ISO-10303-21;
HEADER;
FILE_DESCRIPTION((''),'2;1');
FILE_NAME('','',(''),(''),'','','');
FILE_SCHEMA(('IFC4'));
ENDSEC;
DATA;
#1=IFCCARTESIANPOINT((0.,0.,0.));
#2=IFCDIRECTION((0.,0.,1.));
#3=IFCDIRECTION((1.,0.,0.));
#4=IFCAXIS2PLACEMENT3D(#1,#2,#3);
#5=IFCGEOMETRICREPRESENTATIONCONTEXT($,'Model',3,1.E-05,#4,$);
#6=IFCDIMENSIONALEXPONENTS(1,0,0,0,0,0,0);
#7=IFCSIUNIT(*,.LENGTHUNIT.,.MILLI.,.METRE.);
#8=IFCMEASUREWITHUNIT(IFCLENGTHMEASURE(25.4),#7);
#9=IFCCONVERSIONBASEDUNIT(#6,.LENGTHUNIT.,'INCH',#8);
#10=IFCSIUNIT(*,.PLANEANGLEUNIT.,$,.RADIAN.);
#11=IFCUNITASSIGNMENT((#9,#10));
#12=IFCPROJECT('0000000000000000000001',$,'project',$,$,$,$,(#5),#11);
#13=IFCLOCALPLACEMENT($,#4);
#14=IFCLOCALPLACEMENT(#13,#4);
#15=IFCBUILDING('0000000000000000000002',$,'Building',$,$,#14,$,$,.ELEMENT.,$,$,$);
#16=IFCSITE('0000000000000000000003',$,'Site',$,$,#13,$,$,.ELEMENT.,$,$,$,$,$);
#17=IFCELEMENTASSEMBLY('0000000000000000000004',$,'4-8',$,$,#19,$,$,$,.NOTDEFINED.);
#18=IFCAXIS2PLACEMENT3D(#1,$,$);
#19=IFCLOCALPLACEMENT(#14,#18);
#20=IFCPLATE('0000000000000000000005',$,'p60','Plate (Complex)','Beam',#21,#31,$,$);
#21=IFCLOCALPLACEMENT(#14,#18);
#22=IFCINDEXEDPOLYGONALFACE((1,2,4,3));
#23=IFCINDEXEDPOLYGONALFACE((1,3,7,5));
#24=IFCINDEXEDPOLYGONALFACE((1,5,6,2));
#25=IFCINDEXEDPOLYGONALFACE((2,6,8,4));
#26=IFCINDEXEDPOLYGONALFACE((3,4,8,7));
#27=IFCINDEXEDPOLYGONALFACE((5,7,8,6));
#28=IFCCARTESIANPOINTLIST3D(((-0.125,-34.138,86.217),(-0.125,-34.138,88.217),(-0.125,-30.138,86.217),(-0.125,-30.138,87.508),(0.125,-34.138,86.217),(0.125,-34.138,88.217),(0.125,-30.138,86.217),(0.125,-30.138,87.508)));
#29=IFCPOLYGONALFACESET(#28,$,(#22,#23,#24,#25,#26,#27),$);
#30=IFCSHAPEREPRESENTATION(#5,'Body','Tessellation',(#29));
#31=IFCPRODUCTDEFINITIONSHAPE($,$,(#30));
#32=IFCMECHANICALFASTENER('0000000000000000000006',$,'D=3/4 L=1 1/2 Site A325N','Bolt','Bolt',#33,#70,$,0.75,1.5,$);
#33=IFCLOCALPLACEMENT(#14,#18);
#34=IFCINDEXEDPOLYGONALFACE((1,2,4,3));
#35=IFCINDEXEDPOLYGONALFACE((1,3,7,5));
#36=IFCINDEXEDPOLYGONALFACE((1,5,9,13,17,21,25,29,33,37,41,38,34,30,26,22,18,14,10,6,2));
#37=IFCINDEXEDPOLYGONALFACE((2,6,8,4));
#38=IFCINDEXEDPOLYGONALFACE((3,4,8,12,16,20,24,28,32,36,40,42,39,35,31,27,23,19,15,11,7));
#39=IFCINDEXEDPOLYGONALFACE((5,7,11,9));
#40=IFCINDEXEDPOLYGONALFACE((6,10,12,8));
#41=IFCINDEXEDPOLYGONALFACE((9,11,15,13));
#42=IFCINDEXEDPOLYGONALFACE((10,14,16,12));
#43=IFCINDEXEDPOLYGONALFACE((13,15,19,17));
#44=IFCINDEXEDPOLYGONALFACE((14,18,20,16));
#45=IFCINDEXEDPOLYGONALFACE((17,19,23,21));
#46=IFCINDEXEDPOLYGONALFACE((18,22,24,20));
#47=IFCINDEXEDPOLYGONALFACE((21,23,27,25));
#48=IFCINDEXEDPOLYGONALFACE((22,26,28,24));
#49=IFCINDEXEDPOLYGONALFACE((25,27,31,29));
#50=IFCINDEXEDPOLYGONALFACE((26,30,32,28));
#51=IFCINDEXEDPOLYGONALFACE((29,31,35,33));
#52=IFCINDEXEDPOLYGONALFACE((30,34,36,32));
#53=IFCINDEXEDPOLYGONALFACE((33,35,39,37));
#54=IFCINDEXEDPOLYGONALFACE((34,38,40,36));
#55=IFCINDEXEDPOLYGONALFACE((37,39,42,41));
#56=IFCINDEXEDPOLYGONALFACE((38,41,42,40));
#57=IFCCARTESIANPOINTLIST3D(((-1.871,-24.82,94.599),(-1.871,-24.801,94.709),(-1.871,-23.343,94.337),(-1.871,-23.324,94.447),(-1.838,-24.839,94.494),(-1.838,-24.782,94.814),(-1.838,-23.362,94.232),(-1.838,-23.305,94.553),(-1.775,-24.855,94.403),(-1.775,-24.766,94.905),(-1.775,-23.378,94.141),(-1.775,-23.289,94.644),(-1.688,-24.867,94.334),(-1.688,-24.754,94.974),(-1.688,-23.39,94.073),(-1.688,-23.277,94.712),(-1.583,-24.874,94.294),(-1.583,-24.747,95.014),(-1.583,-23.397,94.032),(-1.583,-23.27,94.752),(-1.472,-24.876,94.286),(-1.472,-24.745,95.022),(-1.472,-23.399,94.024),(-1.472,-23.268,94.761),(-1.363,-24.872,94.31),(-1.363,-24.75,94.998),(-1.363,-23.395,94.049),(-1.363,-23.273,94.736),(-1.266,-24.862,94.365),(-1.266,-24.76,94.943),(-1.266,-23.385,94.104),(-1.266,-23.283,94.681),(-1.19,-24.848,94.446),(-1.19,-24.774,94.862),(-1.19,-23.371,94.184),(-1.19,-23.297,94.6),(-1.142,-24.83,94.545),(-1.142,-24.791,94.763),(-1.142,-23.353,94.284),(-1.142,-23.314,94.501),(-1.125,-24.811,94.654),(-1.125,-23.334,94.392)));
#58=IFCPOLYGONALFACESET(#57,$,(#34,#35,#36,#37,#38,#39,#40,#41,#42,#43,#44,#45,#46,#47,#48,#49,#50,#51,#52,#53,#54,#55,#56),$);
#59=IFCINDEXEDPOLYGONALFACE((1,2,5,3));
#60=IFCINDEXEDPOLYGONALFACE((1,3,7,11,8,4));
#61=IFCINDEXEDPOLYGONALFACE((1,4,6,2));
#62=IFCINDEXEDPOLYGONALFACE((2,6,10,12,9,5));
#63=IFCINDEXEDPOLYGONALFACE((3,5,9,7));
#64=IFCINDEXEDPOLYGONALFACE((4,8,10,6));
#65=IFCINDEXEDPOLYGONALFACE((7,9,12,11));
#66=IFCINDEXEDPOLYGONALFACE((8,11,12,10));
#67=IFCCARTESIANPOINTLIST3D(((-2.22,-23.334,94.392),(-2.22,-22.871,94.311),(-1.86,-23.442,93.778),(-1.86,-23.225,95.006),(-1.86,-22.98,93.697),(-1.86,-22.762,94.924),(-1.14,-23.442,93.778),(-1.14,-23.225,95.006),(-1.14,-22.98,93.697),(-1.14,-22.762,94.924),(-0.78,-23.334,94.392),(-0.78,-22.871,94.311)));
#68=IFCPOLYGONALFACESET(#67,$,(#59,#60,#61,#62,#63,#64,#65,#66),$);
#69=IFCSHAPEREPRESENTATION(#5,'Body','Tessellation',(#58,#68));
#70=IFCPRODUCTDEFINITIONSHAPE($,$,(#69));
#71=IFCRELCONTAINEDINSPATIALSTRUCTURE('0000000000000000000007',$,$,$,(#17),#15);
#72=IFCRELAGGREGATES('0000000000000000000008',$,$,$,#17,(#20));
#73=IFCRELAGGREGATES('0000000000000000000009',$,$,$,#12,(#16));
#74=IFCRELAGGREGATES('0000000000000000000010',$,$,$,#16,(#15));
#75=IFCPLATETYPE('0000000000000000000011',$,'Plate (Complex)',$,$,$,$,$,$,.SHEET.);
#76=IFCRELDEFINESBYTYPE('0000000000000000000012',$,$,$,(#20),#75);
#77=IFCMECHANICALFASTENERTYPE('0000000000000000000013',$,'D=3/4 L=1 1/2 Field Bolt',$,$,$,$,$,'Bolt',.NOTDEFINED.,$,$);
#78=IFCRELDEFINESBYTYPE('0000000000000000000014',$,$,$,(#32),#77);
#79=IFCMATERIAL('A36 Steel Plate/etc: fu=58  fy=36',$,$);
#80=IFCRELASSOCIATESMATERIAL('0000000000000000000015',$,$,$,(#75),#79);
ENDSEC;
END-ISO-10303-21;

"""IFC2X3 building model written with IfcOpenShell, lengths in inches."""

from ifc_helpers import new_model, entity, si_unit, converted_unit, frame, origin_with_axes, origin_2d_with_axis, place, context, project, spatial, polyline, circle, outline, extrude, source, transform, mapped, material, type_object, type_shapes, element, aggregate, save


model = new_model("IFC2X3")

# Units and contexts
model_context = context("Model", 3, precision=1e-05, world=origin_with_axes())
ifc_project = project(units=[converted_unit("LENGTHUNIT", "INCH", entity("IfcLengthMeasure", 25.4), si_unit("LENGTHUNIT", "METRE", prefix="MILLI"), dimensions=[1, 0, 0, 0, 0, 0, 0]), si_unit("PLANEANGLEUNIT", "RADIAN")], contexts=[model_context])

# Site, building
site_placement = place(None, origin_with_axes())
site = spatial("IfcSite", under=ifc_project, at=site_placement, Name="Site", CompositionType="ELEMENT")
building_placement = place(site_placement, origin_with_axes())
building = spatial("IfcBuilding", under=site, at=building_placement, Name="Building", CompositionType="ELEMENT")

# Element assembly
assembly_1_placement = place(building_placement, frame((0.0, -48.0, 94.0), z_axis=(0.0, 0.17437, 0.98468), x_axis=(0.0, 0.98468, -0.17437)))
assembly_1 = element("IfcElementAssembly", 1, at=assembly_1_placement, inside=building, Name="4-8", PredefinedType="NOTDEFINED")

# Plate
ifc_material_1 = material(Name="A36 Steel Plate/etc: fu=58  fy=36")
plate_type_1 = type_object("IfcPlateType", Name="Plate (Complex)", PredefinedType="SHEET", material=ifc_material_1)
shared_shape_1 = source(origin_with_axes(), model_context, "Body", "SweptSolid", [
    extrude(outline(polyline([(0.0, -4.0), (-2.0, -4.0), (-2.0, 0.0), (-0.708, 0.0), (0.0, -4.0)])), frame((-0.125, 0.0, 0.0), z_axis=(1.0, 0.0, 0.0), x_axis=(0.0, 1.0, 0.0)), (0.0, 0.0, 1.0), 0.25),
])
type_shapes(plate_type_1, [shared_shape_1])
plate_1_placement = place(assembly_1_placement, frame((18.597, 0.0, -2.58), z_axis=(0.98468, 0.0, 0.17437), x_axis=(0.0, 1.0, 0.0)))
plate_1 = element("IfcPlate", 2, at=plate_1_placement, type_object=plate_type_1, Name="p60", Description="Plate (Complex)", ObjectType="Beam", context=model_context, shape_type="MappedRepresentation", body=[
    mapped(shared_shape_1, transform((0.0, 0.0, 0.0), scale=1.0)),
])
aggregate(assembly_1, [plate_1])

# Mechanical fastener
mechanical_fastener_type_1 = type_object("IfcMechanicalFastenerType", Name="D=3/4 L=1 1/2 Field Bolt", ElementType="Bolt")
shared_shape_2 = source(origin_with_axes(), model_context, "Body", "SweptSolid", [
    extrude(circle(Radius=0.375, at=origin_2d_with_axis()), frame((0.0, 0.0, 0.0), z_axis=(1.0, 0.0, 0.0), x_axis=(0.0, 1.0, 0.0)), (0.0, 0.0, 1.0), 1.5),
    extrude(outline(polyline([(-0.72, 0.0), (-0.36, 0.624), (0.36, 0.624), (0.72, 0.0), (0.36, -0.624), (-0.36, -0.624), (-0.72, 0.0)])), frame((0.0, 0.0, 0.0), z_axis=(1.0, 0.0, 0.0), x_axis=(0.0, 1.0, 0.0)), (0.0, 0.0, -1.0), 0.47),
])
type_shapes(mechanical_fastener_type_1, [shared_shape_2])
placement_1 = place(assembly_1_placement, frame((24.22, 1.5, 4.688), z_axis=(0.0, 0.0, 1.0), x_axis=(-1.0, 0.0, 0.0)))
mechanical_fastener_1_placement = place(placement_1, origin_with_axes())
element("IfcMechanicalFastener", 3, at=mechanical_fastener_1_placement, type_object=mechanical_fastener_type_1, Name="D=3/4 L=1 1/2 Site A325N", Description="Bolt", ObjectType="Bolt", NominalDiameter=0.75, NominalLength=1.5, context=model_context, shape_type="MappedRepresentation", body=[
    mapped(shared_shape_2, transform((0.0, 0.0, 0.0), scale=1.0)),
])

save(model, "model.ifc")
